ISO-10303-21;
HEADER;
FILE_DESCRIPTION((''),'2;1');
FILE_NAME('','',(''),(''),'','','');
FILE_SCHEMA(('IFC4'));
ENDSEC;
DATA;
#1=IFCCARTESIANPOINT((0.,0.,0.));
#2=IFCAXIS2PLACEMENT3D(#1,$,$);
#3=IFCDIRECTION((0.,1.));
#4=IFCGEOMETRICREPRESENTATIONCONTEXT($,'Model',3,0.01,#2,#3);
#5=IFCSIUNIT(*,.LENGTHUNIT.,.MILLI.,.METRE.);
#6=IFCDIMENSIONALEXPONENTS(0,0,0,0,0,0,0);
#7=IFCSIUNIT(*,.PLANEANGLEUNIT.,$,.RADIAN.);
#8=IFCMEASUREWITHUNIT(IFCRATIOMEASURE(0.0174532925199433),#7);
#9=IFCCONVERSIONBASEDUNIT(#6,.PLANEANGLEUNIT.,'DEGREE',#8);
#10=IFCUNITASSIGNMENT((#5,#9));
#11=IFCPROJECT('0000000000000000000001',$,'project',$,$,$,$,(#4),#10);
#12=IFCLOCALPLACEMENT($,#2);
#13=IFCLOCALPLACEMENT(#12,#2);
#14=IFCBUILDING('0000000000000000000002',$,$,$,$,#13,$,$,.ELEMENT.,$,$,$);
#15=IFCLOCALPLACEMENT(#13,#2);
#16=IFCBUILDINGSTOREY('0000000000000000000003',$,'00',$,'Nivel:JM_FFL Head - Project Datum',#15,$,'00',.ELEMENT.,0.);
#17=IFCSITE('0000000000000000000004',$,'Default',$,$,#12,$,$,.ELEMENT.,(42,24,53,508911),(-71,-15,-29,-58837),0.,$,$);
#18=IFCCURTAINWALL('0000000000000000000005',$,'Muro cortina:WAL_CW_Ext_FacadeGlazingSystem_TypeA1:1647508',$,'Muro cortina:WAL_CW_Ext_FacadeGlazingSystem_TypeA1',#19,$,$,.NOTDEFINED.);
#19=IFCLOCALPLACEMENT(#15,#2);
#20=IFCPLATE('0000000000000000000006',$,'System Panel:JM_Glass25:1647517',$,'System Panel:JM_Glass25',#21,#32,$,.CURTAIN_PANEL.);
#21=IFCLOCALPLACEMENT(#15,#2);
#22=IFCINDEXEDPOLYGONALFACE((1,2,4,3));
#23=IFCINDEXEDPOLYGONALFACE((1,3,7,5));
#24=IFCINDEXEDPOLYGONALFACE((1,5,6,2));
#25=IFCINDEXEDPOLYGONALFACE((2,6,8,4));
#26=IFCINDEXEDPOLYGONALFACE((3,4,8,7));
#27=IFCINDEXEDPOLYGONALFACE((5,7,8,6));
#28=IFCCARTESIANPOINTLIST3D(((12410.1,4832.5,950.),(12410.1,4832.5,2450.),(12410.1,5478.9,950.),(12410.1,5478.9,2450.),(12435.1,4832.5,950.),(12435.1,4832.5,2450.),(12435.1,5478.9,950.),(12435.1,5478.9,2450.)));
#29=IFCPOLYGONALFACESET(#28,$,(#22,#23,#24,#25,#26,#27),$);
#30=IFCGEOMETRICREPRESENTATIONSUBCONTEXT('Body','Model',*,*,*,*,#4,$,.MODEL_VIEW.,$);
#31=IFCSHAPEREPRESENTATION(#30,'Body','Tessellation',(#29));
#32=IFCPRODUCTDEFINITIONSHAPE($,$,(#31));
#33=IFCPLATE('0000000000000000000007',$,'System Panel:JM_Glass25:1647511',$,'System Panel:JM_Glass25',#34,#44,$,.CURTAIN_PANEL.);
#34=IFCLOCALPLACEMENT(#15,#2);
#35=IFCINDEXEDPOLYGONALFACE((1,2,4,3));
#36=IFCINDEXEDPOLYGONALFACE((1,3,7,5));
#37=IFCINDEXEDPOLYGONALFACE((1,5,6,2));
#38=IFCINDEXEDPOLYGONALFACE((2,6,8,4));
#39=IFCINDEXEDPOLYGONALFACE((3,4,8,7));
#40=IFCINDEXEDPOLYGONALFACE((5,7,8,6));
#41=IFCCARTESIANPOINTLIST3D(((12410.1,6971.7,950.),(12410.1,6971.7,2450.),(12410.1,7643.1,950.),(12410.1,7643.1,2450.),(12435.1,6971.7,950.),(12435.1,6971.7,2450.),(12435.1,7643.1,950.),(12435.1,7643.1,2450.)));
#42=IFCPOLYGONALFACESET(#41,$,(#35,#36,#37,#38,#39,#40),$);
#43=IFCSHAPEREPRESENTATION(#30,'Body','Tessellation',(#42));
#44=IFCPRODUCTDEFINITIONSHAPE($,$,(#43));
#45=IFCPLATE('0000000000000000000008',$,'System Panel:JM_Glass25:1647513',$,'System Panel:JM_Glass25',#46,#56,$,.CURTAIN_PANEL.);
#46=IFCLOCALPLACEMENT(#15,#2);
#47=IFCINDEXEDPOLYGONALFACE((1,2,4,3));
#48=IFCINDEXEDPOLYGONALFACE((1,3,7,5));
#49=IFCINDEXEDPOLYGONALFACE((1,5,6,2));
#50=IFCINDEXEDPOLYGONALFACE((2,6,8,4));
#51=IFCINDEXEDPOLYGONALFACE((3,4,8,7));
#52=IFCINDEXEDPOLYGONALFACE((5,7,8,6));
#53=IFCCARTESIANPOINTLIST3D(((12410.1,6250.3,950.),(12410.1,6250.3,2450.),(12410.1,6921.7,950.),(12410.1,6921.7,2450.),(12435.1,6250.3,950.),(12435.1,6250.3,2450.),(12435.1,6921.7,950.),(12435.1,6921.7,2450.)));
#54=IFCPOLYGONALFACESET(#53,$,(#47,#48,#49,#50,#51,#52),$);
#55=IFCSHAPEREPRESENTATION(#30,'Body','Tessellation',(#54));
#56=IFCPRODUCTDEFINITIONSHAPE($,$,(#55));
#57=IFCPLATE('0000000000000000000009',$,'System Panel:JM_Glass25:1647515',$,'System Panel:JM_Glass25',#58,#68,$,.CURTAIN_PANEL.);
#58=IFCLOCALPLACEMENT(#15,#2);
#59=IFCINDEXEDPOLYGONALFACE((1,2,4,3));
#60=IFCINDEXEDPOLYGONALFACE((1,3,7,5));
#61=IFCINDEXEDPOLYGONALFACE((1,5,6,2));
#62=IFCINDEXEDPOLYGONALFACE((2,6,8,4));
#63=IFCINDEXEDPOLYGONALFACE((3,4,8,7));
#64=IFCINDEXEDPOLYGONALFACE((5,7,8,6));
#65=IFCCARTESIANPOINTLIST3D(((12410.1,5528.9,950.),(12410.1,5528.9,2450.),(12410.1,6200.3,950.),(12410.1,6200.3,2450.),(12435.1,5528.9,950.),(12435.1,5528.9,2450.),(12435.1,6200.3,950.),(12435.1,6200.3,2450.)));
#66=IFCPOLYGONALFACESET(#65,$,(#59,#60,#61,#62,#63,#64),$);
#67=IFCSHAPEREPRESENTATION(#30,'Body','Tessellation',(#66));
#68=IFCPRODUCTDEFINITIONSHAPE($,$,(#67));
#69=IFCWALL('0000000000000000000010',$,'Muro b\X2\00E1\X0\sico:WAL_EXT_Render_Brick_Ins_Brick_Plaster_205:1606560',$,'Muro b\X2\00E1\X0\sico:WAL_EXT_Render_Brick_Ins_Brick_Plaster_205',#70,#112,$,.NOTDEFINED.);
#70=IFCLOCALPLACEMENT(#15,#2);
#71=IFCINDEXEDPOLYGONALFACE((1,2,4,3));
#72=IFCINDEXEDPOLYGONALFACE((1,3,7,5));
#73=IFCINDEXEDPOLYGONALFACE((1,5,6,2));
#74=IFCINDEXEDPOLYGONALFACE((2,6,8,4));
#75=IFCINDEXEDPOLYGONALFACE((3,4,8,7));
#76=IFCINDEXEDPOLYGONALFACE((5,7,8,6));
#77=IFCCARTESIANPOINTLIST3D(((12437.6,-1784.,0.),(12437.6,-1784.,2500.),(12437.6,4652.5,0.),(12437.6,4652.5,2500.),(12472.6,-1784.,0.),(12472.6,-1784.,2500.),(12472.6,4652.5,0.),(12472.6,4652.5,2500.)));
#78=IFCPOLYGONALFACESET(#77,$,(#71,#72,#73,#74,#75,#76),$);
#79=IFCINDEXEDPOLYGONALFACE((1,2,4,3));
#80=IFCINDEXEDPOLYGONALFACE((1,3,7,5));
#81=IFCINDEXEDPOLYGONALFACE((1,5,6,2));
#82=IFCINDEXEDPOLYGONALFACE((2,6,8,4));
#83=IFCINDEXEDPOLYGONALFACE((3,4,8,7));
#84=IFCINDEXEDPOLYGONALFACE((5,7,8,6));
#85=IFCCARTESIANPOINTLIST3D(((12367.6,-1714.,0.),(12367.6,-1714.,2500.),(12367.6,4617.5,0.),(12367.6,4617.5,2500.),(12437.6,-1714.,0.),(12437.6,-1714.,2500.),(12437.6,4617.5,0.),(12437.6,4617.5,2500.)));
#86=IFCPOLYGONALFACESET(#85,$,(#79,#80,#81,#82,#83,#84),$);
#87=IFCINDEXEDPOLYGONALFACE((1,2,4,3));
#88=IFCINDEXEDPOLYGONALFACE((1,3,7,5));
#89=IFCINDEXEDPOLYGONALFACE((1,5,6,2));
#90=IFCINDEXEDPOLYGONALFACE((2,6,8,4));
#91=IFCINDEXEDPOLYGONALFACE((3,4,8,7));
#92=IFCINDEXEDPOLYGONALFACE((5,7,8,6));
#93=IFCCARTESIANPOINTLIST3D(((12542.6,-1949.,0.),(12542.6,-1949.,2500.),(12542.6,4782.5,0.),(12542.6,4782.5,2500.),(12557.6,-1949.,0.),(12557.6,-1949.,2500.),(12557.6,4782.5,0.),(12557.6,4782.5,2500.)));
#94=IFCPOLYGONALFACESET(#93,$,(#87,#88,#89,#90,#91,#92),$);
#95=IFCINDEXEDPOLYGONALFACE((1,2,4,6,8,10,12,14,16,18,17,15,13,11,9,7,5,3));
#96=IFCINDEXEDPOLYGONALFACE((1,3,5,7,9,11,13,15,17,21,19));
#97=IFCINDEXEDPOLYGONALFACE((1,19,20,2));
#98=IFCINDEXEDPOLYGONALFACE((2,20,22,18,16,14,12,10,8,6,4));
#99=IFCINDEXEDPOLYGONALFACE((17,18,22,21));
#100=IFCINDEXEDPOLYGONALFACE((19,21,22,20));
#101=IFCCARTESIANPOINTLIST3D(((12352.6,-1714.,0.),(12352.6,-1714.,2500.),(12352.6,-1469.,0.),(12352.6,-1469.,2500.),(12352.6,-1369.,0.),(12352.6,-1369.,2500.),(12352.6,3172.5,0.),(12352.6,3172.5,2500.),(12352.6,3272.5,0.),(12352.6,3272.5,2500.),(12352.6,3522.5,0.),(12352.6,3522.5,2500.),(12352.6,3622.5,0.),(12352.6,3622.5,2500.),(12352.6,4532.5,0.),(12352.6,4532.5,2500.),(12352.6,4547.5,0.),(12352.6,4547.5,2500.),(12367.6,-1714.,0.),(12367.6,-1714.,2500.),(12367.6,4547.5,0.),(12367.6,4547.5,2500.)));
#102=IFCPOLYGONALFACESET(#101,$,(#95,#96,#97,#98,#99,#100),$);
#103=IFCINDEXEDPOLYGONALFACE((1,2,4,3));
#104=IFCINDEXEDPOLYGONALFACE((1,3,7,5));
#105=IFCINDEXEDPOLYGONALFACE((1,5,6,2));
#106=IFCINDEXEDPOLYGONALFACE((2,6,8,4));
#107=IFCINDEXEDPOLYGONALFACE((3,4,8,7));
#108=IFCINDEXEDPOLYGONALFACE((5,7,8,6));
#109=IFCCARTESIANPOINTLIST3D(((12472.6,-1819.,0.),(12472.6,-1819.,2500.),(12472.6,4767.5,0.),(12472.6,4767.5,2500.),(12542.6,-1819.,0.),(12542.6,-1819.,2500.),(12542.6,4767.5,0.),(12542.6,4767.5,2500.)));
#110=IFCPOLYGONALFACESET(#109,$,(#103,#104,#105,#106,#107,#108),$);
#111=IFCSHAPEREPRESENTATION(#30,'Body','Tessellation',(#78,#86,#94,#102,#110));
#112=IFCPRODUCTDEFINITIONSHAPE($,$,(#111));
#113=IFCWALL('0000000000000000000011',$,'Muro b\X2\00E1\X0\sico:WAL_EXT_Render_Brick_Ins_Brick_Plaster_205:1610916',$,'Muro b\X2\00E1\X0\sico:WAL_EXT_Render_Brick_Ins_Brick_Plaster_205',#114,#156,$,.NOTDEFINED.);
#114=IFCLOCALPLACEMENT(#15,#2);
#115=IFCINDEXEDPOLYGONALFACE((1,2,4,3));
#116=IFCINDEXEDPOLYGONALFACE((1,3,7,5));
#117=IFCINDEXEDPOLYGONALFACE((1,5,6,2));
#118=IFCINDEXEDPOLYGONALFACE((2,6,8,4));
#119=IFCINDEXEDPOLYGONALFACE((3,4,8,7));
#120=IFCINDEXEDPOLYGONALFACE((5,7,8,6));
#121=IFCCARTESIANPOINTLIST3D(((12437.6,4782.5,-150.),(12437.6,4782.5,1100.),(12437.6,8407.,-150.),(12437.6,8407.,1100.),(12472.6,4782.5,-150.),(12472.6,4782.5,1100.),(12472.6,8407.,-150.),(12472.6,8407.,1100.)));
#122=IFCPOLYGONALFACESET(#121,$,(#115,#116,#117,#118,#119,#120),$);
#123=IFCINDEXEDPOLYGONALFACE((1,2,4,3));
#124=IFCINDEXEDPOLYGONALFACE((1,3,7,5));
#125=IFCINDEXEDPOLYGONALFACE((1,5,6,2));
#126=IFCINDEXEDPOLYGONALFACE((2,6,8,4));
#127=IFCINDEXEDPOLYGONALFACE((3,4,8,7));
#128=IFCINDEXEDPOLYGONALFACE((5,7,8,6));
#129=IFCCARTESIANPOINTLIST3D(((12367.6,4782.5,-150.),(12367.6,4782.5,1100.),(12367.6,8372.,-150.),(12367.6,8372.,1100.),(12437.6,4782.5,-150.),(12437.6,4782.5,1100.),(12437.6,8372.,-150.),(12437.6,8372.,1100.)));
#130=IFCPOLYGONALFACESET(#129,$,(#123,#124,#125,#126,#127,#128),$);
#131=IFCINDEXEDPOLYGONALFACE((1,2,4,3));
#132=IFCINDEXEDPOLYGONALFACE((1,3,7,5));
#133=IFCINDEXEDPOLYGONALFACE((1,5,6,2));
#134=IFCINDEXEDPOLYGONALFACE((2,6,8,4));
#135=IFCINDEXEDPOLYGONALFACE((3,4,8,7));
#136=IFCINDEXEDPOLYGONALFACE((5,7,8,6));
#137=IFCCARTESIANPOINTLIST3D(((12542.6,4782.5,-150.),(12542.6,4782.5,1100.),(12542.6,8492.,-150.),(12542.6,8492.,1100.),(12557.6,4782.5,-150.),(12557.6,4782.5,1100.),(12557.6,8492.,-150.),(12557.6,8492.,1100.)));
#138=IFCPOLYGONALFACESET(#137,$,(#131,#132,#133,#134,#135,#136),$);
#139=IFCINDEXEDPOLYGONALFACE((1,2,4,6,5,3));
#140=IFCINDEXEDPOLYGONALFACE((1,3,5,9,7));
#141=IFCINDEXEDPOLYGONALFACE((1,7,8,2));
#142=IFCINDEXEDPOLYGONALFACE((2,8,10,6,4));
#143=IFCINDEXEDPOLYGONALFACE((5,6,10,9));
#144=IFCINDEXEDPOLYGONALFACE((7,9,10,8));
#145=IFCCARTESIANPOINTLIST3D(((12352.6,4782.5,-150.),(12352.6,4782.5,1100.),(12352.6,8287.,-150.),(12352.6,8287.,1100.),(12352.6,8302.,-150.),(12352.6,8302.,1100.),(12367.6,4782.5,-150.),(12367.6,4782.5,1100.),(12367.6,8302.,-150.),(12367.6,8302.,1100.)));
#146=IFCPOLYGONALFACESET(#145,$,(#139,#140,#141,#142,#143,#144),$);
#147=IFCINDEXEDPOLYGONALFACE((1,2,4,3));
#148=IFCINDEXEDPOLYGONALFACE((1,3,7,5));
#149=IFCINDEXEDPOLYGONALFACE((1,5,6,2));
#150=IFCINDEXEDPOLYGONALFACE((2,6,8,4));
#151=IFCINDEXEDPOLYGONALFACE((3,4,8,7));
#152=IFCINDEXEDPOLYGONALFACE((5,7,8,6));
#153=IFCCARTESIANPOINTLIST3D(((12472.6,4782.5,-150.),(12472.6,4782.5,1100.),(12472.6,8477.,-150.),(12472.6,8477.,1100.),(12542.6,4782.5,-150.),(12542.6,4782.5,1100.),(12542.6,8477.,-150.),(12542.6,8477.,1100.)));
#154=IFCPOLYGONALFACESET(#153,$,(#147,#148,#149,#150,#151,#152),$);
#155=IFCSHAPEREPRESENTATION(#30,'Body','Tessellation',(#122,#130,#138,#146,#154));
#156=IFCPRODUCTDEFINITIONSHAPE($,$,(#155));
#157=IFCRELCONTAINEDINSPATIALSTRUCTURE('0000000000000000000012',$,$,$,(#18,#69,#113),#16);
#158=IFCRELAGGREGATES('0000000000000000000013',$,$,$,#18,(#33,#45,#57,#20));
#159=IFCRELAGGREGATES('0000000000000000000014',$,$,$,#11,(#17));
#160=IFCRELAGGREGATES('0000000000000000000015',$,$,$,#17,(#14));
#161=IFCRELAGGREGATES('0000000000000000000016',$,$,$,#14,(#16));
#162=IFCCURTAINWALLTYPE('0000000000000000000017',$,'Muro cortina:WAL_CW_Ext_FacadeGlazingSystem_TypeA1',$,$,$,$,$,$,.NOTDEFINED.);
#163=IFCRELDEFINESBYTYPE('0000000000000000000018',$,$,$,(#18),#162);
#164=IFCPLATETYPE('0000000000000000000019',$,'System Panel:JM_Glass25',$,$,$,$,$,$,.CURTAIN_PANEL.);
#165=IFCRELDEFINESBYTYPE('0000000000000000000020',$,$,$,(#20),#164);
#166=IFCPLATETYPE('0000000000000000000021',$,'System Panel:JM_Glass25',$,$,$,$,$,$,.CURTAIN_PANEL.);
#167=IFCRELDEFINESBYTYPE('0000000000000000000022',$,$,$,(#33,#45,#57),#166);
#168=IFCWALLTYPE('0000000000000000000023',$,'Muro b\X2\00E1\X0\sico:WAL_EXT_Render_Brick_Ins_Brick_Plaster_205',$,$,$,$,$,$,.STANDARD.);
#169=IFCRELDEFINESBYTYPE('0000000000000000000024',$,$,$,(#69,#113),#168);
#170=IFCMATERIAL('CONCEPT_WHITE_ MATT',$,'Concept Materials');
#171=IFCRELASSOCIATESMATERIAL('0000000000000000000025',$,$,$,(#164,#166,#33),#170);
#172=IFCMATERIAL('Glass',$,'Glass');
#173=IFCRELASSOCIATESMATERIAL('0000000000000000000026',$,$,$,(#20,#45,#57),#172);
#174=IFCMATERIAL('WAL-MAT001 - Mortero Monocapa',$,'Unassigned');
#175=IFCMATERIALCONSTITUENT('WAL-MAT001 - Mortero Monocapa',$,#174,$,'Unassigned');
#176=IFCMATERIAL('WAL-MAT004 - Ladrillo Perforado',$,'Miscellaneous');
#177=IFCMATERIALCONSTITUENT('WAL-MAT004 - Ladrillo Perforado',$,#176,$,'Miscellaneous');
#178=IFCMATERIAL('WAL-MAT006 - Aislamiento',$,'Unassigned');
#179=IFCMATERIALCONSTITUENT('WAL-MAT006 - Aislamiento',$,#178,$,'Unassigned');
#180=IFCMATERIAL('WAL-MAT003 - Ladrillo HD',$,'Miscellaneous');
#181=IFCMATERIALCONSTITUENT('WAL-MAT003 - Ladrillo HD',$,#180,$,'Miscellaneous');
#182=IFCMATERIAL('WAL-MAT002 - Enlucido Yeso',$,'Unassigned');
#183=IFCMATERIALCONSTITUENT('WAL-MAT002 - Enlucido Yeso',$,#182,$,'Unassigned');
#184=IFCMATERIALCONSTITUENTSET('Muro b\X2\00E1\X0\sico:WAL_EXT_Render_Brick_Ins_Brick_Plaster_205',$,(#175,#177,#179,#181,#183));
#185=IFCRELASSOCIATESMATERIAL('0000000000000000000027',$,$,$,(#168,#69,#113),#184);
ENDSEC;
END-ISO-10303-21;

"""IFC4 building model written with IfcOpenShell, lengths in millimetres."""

from ifc_helpers import new_model, entity, si_unit, converted_unit, direction, frame, origin, place, context, subcontext, project, spatial, indexed_curve, outline, extrude, source, transform, mapped, material, constituent, constituent_set, type_object, type_shapes, element, aggregate, save


model = new_model("IFC4")

# Units and contexts
model_context = context("Model", 3, precision=0.01, world=origin(), true_north=direction((0.0, 1.0)))
body_context = subcontext(model_context, "Body", "Model", "MODEL_VIEW")
ifc_project = project(units=[si_unit("LENGTHUNIT", "METRE", prefix="MILLI"), converted_unit("PLANEANGLEUNIT", "DEGREE", entity("IfcRatioMeasure", 0.0174532925199433), si_unit("PLANEANGLEUNIT", "RADIAN"), dimensions=[0, 0, 0, 0, 0, 0, 0])], contexts=[model_context])

# Site, building, storey
site_placement = place(None, origin())
site = spatial("IfcSite", under=ifc_project, at=site_placement, Name="Default", CompositionType="ELEMENT", RefLatitude=(42, 24, 53, 508911), RefLongitude=(-71, -15, -29, -58837), RefElevation=0.0)
building_placement = place(site_placement, origin())
building = spatial("IfcBuilding", under=site, at=building_placement, CompositionType="ELEMENT")
storey_placement = place(building_placement, origin())
storey = spatial("IfcBuildingStorey", under=building, at=storey_placement, Name="00", ObjectType="Nivel:JM_FFL Head - Project Datum", LongName="00", CompositionType="ELEMENT", Elevation=0.0)

# Curtain wall
curtain_wall_type = type_object("IfcCurtainWallType", Name="Muro cortina:WAL_CW_Ext_FacadeGlazingSystem_TypeA1", PredefinedType="NOTDEFINED")
curtain_wall_1_placement = place(storey_placement, origin())
curtain_wall_1 = element("IfcCurtainWall", 1, at=curtain_wall_1_placement, inside=storey, type_object=curtain_wall_type, Name="Muro cortina:WAL_CW_Ext_FacadeGlazingSystem_TypeA1:1647508", ObjectType="Muro cortina:WAL_CW_Ext_FacadeGlazingSystem_TypeA1", PredefinedType="NOTDEFINED")

# Plates
ifc_material_1 = material(Name="CONCEPT_WHITE_ MATT", Category="Concept Materials")
plate_type_1 = type_object("IfcPlateType", Name="System Panel:JM_Glass25", PredefinedType="CURTAIN_PANEL", material=ifc_material_1)
shared_shape_1 = source(origin(), body_context, "Body", "SweptSolid", [
    extrude(outline(indexed_curve([(-12.5, -323.2), (12.5, -323.2), (12.5, 323.2), (-12.5, 323.2), (-12.5, -323.2)], self_intersect=False)), frame((0.0, -32.5, 0.0), z_axis=(0.0, 0.0, 1.0), x_axis=(0.0, 1.0, 0.0)), (0.0, 0.0, 1.0), 1500.0),
])
type_shapes(plate_type_1, [shared_shape_1])
ifc_material_2 = material(Name="Glass", Category="Glass")
plate_1_placement = place(curtain_wall_1_placement, frame((12455.1, 5155.7, 950.0), z_axis=(0.0, 0.0, 1.0), x_axis=(0.0, -1.0, 0.0)))
plate_1 = element("IfcPlate", 2, at=plate_1_placement, type_object=plate_type_1, material=ifc_material_2, Name="System Panel:JM_Glass25:1647517", ObjectType="System Panel:JM_Glass25", PredefinedType="CURTAIN_PANEL", context=body_context, shape_type="MappedRepresentation", body=[
    mapped(shared_shape_1, transform((0.0, 0.0, 0.0), scale=1.0)),
])
plate_type_2 = type_object("IfcPlateType", Name="System Panel:JM_Glass25", PredefinedType="CURTAIN_PANEL", material=ifc_material_1)
shared_shape_2 = source(origin(), body_context, "Body", "SweptSolid", [
    extrude(outline(indexed_curve([(-12.5, -335.7), (12.5, -335.7), (12.5, 335.7), (-12.5, 335.7), (-12.5, -335.7)], self_intersect=False)), frame((0.0, -32.5, 0.0), z_axis=(0.0, 0.0, 1.0), x_axis=(0.0, 1.0, 0.0)), (0.0, 0.0, 1.0), 1500.0),
])
type_shapes(plate_type_2, [shared_shape_2])
plate_2_placement = place(curtain_wall_1_placement, frame((12455.1, 7307.4, 950.0), z_axis=(0.0, 0.0, 1.0), x_axis=(0.0, -1.0, 0.0)))
plate_2 = element("IfcPlate", 3, at=plate_2_placement, type_object=plate_type_2, material=ifc_material_1, Name="System Panel:JM_Glass25:1647511", ObjectType="System Panel:JM_Glass25", PredefinedType="CURTAIN_PANEL", context=body_context, shape_type="MappedRepresentation", body=[
    mapped(shared_shape_2, transform((0.0, 0.0, 0.0), scale=1.0)),
])
plate_3_placement = place(curtain_wall_1_placement, frame((12455.1, 6586.0, 950.0), z_axis=(0.0, 0.0, 1.0), x_axis=(0.0, -1.0, 0.0)))
plate_3 = element("IfcPlate", 4, at=plate_3_placement, type_object=plate_type_2, material=ifc_material_2, Name="System Panel:JM_Glass25:1647513", ObjectType="System Panel:JM_Glass25", PredefinedType="CURTAIN_PANEL", context=body_context, shape_type="MappedRepresentation", body=[
    mapped(shared_shape_2, transform((0.0, 0.0, 0.0), scale=1.0)),
])
plate_4_placement = place(curtain_wall_1_placement, frame((12455.1, 5864.6, 950.0), z_axis=(0.0, 0.0, 1.0), x_axis=(0.0, -1.0, 0.0)))
plate_4 = element("IfcPlate", 5, at=plate_4_placement, type_object=plate_type_2, material=ifc_material_2, Name="System Panel:JM_Glass25:1647515", ObjectType="System Panel:JM_Glass25", PredefinedType="CURTAIN_PANEL", context=body_context, shape_type="MappedRepresentation", body=[
    mapped(shared_shape_2, transform((0.0, 0.0, 0.0), scale=1.0)),
])
aggregate(curtain_wall_1, [plate_2, plate_3, plate_4, plate_1])

# Walls
ifc_material_3 = material(Name="WAL-MAT001 - Mortero Monocapa", Category="Unassigned")
ifc_constituent_1 = constituent(ifc_material_3, Name="WAL-MAT001 - Mortero Monocapa", Category="Unassigned")
ifc_material_4 = material(Name="WAL-MAT004 - Ladrillo Perforado", Category="Miscellaneous")
ifc_constituent_2 = constituent(ifc_material_4, Name="WAL-MAT004 - Ladrillo Perforado", Category="Miscellaneous")
ifc_material_5 = material(Name="WAL-MAT006 - Aislamiento", Category="Unassigned")
ifc_constituent_3 = constituent(ifc_material_5, Name="WAL-MAT006 - Aislamiento", Category="Unassigned")
ifc_material_6 = material(Name="WAL-MAT003 - Ladrillo HD", Category="Miscellaneous")
ifc_constituent_4 = constituent(ifc_material_6, Name="WAL-MAT003 - Ladrillo HD", Category="Miscellaneous")
ifc_material_7 = material(Name="WAL-MAT002 - Enlucido Yeso", Category="Unassigned")
ifc_constituent_5 = constituent(ifc_material_7, Name="WAL-MAT002 - Enlucido Yeso", Category="Unassigned")
ifc_constituent_set_1 = constituent_set(constituents=[ifc_constituent_1, ifc_constituent_2, ifc_constituent_3, ifc_constituent_4, ifc_constituent_5], Name="Muro básico:WAL_EXT_Render_Brick_Ins_Brick_Plaster_205")
wall_type_1 = type_object("IfcWallType", Name="Muro básico:WAL_EXT_Render_Brick_Ins_Brick_Plaster_205", PredefinedType="STANDARD", material=ifc_constituent_set_1)
wall_1_placement = place(storey_placement, frame((12455.1, 4782.5, 0.0), z_axis=(0.0, 0.0, 1.0), x_axis=(0.0, -1.0, 0.0)))
element("IfcWall", 6, at=wall_1_placement, inside=storey, type_object=wall_type_1, material=ifc_constituent_set_1, Name="Muro básico:WAL_EXT_Render_Brick_Ins_Brick_Plaster_205:1606560", ObjectType="Muro básico:WAL_EXT_Render_Brick_Ins_Brick_Plaster_205", PredefinedType="NOTDEFINED", context=body_context, shape_type="SweptSolid", body=[
    extrude(outline(indexed_curve([(-17.5, -3218.3), (17.5, -3218.3), (17.5, 3218.3), (-17.5, 3218.3), (-17.5, -3218.3)], self_intersect=False)), frame((3348.3, 0.0, 0.0), z_axis=(0.0, 0.0, 1.0), x_axis=(0.0, 1.0, 0.0)), (0.0, 0.0, 1.0), 2500.0),
    extrude(outline(indexed_curve([(-35.0, -3165.8), (35.0, -3165.8), (35.0, 3165.8), (-35.0, 3165.8), (-35.0, -3165.8)], self_intersect=False)), frame((3330.8, -52.5, 0.0), z_axis=(0.0, 0.0, 1.0), x_axis=(0.0, -1.0, 0.0)), (0.0, 0.0, 1.0), 2500.0),
    extrude(outline(indexed_curve([(-7.5, -3365.8), (7.5, -3365.8), (7.5, 3365.8), (-7.5, 3365.8), (-7.5, -3365.8)], self_intersect=False)), frame((3365.8, 95.0, 0.0), z_axis=(0.0, 0.0, 1.0), x_axis=(0.0, 1.0, 0.0)), (0.0, 0.0, 1.0), 2500.0),
    extrude(outline(indexed_curve([(-12.3, -2642.8), (2.7, -2642.8), (2.7, -2627.8), (2.7, -1717.8), (2.7, -1617.8), (2.7, -1367.8), (2.7, -1267.8), (2.7, 3273.7), (2.7, 3373.7), (2.7, 3618.7), (-12.3, 3618.7), (-12.3, -2642.8)], self_intersect=False)), frame((2877.8, -99.8, 0.0), z_axis=(0.0, 0.0, 1.0), x_axis=(0.0, -1.0, 0.0)), (0.0, 0.0, 1.0), 2500.0),
    extrude(outline(indexed_curve([(-35.0, -3293.3), (35.0, -3293.3), (35.0, 3293.3), (-35.0, 3293.3), (-35.0, -3293.3)], self_intersect=False)), frame((3308.3, 52.5, 0.0), z_axis=(0.0, 0.0, 1.0), x_axis=(0.0, 1.0, 0.0)), (0.0, 0.0, 1.0), 2500.0),
])
wall_2_placement = place(storey_placement, frame((12455.1, 4782.5, -150.0), z_axis=(0.0, 0.0, 1.0), x_axis=(0.0, 1.0, 0.0)))
element("IfcWall", 7, at=wall_2_placement, inside=storey, type_object=wall_type_1, material=ifc_constituent_set_1, Name="Muro básico:WAL_EXT_Render_Brick_Ins_Brick_Plaster_205:1610916", ObjectType="Muro básico:WAL_EXT_Render_Brick_Ins_Brick_Plaster_205", PredefinedType="NOTDEFINED", context=body_context, shape_type="SweptSolid", body=[
    extrude(outline(indexed_curve([(-1812.2, -17.5), (1812.2, -17.5), (1812.2, 17.5), (-1812.2, 17.5), (-1812.2, -17.5)], self_intersect=False)), frame((1812.2, 0.0, 0.0)), (0.0, 0.0, 1.0), 1250.0),
    extrude(outline(indexed_curve([(-1794.7, -35.0), (1794.7, -35.0), (1794.7, 35.0), (-1794.7, 35.0), (-1794.7, -35.0)], self_intersect=False)), frame((1794.7, 52.5, 0.0)), (0.0, 0.0, 1.0), 1250.0),
    extrude(outline(indexed_curve([(-7.5, -1854.7), (7.5, -1854.7), (7.5, 1854.7), (-7.5, 1854.7), (-7.5, -1854.7)], self_intersect=False)), frame((1854.7, -95.0, 0.0), z_axis=(0.0, 0.0, 1.0), x_axis=(0.0, 1.0, 0.0)), (0.0, 0.0, 1.0), 1250.0),
    extrude(outline(indexed_curve([(-1395.8, -6.0), (2108.7, -6.0), (2108.7, 9.0), (-1410.8, 9.0), (-1410.8, -6.0), (-1395.8, -6.0)], self_intersect=False)), frame((2108.7, 96.5, 0.0), z_axis=(0.0, 0.0, 1.0), x_axis=(-1.0, 0.0, 0.0)), (0.0, 0.0, 1.0), 1250.0),
    extrude(outline(indexed_curve([(-1847.2, -35.0), (1847.2, -35.0), (1847.2, 35.0), (-1847.2, 35.0), (-1847.2, -35.0)], self_intersect=False)), frame((1847.2, -52.5, 0.0)), (0.0, 0.0, 1.0), 1250.0),
])

save(model, "model.ifc")
